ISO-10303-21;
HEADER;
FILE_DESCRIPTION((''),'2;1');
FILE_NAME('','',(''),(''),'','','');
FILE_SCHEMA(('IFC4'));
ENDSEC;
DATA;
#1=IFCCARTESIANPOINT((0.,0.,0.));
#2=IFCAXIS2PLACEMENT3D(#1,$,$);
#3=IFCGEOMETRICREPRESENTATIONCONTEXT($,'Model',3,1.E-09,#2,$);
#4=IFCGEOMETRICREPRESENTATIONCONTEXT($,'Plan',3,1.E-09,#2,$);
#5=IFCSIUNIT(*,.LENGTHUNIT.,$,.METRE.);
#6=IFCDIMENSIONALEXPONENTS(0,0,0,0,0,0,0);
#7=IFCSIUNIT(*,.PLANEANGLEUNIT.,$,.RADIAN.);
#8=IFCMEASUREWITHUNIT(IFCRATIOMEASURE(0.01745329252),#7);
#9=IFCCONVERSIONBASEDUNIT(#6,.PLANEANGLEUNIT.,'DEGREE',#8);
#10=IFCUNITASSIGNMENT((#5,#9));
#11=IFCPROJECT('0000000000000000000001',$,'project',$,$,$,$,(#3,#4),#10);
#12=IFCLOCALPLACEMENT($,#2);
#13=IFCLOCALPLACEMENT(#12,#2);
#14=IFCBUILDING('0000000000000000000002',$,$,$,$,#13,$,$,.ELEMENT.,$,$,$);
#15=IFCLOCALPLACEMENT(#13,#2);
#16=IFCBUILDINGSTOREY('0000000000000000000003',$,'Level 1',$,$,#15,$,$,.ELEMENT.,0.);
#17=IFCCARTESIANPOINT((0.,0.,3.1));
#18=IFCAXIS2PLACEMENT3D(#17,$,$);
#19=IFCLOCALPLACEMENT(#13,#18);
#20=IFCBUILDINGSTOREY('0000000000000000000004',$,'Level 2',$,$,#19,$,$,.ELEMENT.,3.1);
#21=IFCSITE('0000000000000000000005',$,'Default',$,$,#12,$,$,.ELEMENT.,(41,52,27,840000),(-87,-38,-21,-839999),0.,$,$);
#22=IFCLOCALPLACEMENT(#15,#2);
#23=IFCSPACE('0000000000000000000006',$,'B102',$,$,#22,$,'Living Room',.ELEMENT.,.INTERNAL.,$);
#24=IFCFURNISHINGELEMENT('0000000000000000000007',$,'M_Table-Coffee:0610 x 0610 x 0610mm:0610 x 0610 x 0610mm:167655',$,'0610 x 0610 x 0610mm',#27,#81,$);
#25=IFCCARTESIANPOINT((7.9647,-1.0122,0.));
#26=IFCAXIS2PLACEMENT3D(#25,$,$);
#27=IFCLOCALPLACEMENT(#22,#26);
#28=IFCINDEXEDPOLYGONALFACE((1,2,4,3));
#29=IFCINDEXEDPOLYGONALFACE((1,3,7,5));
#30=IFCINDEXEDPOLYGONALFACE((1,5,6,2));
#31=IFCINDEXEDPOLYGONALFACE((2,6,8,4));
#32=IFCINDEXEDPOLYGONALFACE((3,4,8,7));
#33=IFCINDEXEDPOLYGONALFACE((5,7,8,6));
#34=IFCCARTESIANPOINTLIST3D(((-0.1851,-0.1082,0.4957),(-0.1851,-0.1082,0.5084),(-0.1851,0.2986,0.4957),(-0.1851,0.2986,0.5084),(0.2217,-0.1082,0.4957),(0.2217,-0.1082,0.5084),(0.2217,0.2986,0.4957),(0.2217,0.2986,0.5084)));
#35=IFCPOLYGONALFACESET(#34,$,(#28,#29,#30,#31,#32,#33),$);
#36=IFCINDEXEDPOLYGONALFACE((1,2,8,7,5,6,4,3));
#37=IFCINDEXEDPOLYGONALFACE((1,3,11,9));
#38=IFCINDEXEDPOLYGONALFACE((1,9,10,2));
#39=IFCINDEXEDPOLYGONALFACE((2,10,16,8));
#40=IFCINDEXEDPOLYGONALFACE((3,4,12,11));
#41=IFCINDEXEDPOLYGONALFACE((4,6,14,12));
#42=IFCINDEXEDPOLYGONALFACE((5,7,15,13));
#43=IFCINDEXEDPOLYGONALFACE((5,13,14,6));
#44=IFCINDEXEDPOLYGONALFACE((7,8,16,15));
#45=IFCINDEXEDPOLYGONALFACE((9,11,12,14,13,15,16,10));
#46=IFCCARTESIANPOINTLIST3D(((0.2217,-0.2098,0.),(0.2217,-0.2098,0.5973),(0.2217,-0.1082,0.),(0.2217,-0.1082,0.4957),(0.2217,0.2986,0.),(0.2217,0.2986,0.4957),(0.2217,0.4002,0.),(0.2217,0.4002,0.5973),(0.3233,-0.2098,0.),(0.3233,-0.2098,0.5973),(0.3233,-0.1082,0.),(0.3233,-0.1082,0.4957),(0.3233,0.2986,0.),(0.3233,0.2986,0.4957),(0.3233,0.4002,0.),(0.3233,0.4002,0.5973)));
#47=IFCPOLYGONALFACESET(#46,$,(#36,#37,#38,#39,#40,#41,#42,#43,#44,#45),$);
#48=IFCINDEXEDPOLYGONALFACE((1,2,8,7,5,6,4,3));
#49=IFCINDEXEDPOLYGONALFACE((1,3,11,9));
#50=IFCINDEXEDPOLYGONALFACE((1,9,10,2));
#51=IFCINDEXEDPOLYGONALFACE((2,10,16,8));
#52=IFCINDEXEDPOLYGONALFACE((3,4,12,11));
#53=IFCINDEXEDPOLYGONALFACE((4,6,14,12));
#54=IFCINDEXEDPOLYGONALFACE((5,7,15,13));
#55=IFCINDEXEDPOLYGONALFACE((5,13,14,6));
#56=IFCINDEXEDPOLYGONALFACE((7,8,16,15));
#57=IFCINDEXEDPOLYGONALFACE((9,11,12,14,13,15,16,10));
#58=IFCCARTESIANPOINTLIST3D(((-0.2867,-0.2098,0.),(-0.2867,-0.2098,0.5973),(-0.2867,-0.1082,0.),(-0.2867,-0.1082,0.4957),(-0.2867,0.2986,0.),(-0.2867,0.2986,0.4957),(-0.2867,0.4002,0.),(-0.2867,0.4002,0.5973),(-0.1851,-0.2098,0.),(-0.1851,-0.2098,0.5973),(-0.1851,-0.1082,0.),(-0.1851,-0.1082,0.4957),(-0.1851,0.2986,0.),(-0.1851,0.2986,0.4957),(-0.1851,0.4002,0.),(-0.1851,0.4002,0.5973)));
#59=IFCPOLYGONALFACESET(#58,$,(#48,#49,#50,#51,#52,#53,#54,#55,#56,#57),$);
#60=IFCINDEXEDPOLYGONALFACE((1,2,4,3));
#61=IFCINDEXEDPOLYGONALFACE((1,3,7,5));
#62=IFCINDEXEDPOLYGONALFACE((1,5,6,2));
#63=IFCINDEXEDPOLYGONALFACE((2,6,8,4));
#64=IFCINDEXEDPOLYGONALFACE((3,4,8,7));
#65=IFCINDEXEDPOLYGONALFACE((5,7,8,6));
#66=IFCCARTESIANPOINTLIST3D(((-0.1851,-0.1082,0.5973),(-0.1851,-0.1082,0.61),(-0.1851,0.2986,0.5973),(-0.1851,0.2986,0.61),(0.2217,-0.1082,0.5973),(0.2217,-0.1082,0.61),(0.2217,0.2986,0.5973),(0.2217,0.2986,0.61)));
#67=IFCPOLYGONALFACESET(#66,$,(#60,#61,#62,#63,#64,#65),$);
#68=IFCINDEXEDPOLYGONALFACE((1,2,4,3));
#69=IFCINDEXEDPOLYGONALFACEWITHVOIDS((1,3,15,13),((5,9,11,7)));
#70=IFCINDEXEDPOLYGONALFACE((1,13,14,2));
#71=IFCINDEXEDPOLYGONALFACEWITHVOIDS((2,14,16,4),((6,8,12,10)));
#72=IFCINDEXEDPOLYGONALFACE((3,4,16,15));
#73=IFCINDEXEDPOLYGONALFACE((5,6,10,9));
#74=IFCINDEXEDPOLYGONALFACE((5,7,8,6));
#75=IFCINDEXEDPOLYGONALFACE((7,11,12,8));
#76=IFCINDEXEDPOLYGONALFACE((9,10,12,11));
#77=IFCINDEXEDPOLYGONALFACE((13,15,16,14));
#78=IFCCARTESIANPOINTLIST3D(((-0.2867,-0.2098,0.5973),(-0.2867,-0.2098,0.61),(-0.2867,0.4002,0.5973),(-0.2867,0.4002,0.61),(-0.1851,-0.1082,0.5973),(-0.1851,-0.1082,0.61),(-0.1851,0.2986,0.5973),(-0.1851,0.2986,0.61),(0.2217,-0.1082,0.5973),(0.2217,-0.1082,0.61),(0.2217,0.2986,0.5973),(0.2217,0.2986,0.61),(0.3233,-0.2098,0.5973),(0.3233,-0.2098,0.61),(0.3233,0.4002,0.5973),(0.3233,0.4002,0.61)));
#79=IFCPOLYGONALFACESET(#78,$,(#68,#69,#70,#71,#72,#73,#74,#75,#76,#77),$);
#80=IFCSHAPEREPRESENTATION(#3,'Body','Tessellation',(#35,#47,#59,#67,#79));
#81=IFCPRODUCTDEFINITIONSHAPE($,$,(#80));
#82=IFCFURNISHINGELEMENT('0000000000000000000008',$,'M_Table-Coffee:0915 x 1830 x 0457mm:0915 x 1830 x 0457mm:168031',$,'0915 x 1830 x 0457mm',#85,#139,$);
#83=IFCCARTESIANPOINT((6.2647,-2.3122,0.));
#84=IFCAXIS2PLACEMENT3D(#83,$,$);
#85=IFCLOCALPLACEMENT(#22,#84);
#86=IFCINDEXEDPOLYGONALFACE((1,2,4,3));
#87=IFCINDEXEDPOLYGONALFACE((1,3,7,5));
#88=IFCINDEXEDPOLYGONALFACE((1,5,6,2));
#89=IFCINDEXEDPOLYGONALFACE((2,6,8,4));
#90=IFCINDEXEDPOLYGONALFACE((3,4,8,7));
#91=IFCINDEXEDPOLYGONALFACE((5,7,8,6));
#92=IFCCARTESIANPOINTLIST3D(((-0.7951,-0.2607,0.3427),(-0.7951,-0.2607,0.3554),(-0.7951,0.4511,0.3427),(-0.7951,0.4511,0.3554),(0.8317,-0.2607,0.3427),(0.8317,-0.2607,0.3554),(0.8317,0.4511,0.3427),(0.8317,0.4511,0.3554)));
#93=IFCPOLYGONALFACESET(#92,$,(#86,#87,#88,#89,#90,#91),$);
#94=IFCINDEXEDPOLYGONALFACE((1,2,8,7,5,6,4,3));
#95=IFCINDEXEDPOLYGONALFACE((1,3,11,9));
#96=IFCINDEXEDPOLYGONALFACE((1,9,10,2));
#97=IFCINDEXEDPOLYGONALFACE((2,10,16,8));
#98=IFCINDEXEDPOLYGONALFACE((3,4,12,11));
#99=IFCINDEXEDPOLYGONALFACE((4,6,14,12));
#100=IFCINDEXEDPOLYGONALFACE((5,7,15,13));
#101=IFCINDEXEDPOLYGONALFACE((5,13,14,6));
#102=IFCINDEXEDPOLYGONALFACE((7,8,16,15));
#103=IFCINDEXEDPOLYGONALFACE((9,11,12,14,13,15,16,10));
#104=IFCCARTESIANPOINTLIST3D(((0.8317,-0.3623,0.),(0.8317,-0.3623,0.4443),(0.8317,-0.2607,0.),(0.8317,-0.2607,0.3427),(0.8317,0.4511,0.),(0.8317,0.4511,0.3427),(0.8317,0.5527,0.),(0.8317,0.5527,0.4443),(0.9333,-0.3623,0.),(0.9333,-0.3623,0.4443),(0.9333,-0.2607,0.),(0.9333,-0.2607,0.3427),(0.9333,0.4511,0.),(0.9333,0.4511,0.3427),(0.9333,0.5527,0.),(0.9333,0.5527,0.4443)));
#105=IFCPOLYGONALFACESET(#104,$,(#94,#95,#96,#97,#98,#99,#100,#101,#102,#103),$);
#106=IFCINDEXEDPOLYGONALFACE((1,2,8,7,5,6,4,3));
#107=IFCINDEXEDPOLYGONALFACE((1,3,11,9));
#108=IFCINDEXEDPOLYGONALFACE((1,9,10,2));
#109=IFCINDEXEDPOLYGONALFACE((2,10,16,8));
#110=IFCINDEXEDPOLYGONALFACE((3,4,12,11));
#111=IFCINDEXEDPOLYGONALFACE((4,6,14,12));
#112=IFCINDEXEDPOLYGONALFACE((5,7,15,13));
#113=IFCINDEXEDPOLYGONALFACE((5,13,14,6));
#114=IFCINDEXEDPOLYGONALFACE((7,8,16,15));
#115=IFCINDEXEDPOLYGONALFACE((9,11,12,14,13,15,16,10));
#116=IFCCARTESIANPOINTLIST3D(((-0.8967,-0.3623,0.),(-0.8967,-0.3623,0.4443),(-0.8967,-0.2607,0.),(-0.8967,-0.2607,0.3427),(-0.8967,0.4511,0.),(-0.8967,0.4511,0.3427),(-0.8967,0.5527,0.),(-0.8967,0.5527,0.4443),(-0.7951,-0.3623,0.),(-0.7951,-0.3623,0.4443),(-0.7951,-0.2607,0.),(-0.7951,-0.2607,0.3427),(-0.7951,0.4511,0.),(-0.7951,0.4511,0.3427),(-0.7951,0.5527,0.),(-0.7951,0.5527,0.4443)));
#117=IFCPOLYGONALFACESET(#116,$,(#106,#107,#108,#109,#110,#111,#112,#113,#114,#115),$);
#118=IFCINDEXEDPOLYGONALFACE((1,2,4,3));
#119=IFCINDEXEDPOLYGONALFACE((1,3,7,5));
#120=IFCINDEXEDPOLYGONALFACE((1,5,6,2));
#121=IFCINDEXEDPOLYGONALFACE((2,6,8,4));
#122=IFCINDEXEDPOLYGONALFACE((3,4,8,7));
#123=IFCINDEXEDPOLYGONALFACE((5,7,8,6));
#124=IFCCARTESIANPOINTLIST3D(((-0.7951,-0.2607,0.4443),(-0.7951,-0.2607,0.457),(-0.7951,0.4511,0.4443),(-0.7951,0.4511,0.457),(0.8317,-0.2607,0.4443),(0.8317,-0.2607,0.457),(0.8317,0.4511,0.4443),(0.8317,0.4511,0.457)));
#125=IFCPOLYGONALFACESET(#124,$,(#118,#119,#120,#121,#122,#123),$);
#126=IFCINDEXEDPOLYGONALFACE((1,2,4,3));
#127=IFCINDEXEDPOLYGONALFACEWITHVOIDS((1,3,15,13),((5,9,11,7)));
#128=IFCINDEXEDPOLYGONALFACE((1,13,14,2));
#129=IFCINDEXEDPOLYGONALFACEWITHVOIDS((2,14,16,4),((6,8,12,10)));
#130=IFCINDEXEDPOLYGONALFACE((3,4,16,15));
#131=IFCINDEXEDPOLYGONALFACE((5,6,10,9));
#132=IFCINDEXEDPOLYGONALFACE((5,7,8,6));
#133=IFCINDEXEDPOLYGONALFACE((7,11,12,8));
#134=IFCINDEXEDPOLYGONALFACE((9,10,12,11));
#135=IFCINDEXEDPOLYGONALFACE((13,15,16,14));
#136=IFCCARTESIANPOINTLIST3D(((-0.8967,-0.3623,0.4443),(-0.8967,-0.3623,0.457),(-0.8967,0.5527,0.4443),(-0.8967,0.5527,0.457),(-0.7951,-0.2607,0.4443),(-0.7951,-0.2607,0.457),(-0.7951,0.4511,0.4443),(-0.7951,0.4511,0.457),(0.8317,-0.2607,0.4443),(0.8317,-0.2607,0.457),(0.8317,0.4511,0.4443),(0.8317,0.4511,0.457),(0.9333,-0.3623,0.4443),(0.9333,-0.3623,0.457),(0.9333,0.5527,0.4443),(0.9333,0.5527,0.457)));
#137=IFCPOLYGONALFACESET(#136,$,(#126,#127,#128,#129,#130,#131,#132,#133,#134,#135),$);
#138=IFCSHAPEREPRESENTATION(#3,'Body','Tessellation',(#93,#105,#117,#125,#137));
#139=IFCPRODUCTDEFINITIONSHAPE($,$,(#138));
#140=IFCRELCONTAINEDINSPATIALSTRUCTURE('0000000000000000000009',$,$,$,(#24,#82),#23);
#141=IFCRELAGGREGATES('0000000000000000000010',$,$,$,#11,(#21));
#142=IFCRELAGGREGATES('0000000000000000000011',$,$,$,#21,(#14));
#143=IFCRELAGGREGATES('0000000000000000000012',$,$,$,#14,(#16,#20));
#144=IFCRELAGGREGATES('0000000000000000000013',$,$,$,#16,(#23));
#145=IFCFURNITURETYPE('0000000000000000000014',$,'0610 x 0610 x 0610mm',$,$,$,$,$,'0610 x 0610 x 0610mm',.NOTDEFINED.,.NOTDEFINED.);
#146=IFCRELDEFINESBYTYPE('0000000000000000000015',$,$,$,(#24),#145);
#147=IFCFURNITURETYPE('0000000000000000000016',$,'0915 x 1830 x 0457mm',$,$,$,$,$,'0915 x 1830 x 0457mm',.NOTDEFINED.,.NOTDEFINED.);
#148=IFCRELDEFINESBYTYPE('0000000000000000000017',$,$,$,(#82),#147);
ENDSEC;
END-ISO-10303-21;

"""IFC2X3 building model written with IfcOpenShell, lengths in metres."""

from ifc_helpers import new_model, entity, si_unit, converted_unit, frame, origin, origin_2d_with_axis, place, context, project, spatial, polyline, rectangle, outline, extrude, source, transform, mapped, type_object, type_shapes, element, save


model = new_model("IFC2X3")

# Units and contexts
model_context = context("Model", 3, precision=1e-09, world=origin())
plan_context = context("Plan", 3, precision=1e-09, world=origin())
ifc_project = project(units=[si_unit("LENGTHUNIT", "METRE"), converted_unit("PLANEANGLEUNIT", "DEGREE", entity("IfcRatioMeasure", 0.01745329252), si_unit("PLANEANGLEUNIT", "RADIAN"), dimensions=[0, 0, 0, 0, 0, 0, 0])], contexts=[model_context, plan_context])

# Site, building, storey
site_placement = place(None, origin())
site = spatial("IfcSite", under=ifc_project, at=site_placement, Name="Default", CompositionType="ELEMENT", RefLatitude=(41, 52, 27, 840000), RefLongitude=(-87, -38, -21, -839999), RefElevation=0.0)
building_placement = place(site_placement, origin())
building = spatial("IfcBuilding", under=site, at=building_placement, CompositionType="ELEMENT")
storey_1_placement = place(building_placement, origin())
storey_1 = spatial("IfcBuildingStorey", under=building, at=storey_1_placement, Name="Level 1", CompositionType="ELEMENT", Elevation=0.0)

# Shared definitions
storey_2_placement = place(building_placement, frame((0.0, 0.0, 3.1)))
storey_2 = spatial("IfcBuildingStorey", under=building, at=storey_2_placement, Name="Level 2", CompositionType="ELEMENT", Elevation=3.1)

# Shared definitions
space_1_placement = place(storey_1_placement, origin())
space_1 = spatial("IfcSpace", under=storey_1, at=space_1_placement, Name="B102", LongName="Living Room", CompositionType="ELEMENT", InteriorOrExteriorSpace="INTERNAL")

# Furnishing elements
furniture_type_1 = type_object("IfcFurnitureType", Name="0610 x 0610 x 0610mm", ElementType="0610 x 0610 x 0610mm", AssemblyPlace="NOTDEFINED")
shared_shape_1 = source(origin(), model_context, "Body", "SweptSolid", [
    extrude(rectangle(XDim=0.4068, YDim=0.4068, at=origin_2d_with_axis()), frame((0.0183, 0.0952, 0.4957), z_axis=(0.0, 0.0, 1.0), x_axis=(-1.0, 0.0, 0.0)), (0.0, 0.0, 1.0), 0.0127),
    extrude(outline(polyline([(-0.2732, -0.305), (0.3241, -0.305), (0.3241, 0.305), (-0.2732, 0.305), (-0.2732, 0.2034), (0.2225, 0.2034), (0.2225, -0.2034), (-0.2732, -0.2034), (-0.2732, -0.305)])), frame((0.2217, 0.0952, 0.2732), z_axis=(1.0, 0.0, 0.0), x_axis=(0.0, 0.0, 1.0)), (0.0, 0.0, 1.0), 0.1016),
    extrude(outline(polyline([(-0.305, -0.3241), (0.305, -0.3241), (0.305, 0.2732), (0.2034, 0.2732), (0.2034, -0.2225), (-0.2034, -0.2225), (-0.2034, 0.2732), (-0.305, 0.2732), (-0.305, -0.3241)])), frame((-0.2867, 0.0952, 0.2732), z_axis=(1.0, 0.0, 0.0), x_axis=(0.0, -1.0, 0.0)), (0.0, 0.0, 1.0), 0.1016),
    extrude(rectangle(XDim=0.4068, YDim=0.4068, at=origin_2d_with_axis()), frame((0.0183, 0.0952, 0.5973), z_axis=(0.0, 0.0, 1.0), x_axis=(-1.0, 0.0, 0.0)), (0.0, 0.0, 1.0), 0.0127),
    extrude(outline(polyline([(-0.305, -0.305), (0.305, -0.305), (0.305, 0.305), (-0.305, 0.305), (-0.305, -0.305)]), holes=[polyline([(-0.2034, -0.2034), (-0.2034, 0.2034), (0.2034, 0.2034), (0.2034, -0.2034), (-0.2034, -0.2034)])]), frame((0.0183, 0.0952, 0.5973), z_axis=(0.0, 0.0, 1.0), x_axis=(-1.0, 0.0, 0.0)), (0.0, 0.0, 1.0), 0.0127),
])
type_shapes(furniture_type_1, [shared_shape_1])
for number, where, name in (
    (1, (7.9647, -1.0122, 0.0), "M_Table-Coffee:0610 x 0610 x 0610mm:0610 x 0610 x 0610mm:167655"),
):
    element("IfcFurnishingElement", number, at=place(space_1_placement, frame(where)), inside=space_1, type_object=furniture_type_1, Name=name, ObjectType="0610 x 0610 x 0610mm", context=model_context, shape_type="MappedRepresentation", body=[
        mapped(shared_shape_1, transform((0.0, 0.0, 0.0), scale=1.0)),
    ])
furniture_type_2 = type_object("IfcFurnitureType", Name="0915 x 1830 x 0457mm", ElementType="0915 x 1830 x 0457mm", AssemblyPlace="NOTDEFINED")
shared_shape_2 = source(origin(), model_context, "Body", "SweptSolid", [
    extrude(rectangle(XDim=1.6268, YDim=0.7118, at=origin_2d_with_axis()), frame((0.0183, 0.0952, 0.3427), z_axis=(0.0, 0.0, 1.0), x_axis=(-1.0, 0.0, 0.0)), (0.0, 0.0, 1.0), 0.0127),
    extrude(outline(polyline([(-0.1968, -0.4575), (0.2475, -0.4575), (0.2475, 0.4575), (-0.1968, 0.4575), (-0.1968, 0.3559), (0.1459, 0.3559), (0.1459, -0.3559), (-0.1968, -0.3559), (-0.1968, -0.4575)])), frame((0.8317, 0.0952, 0.1968), z_axis=(1.0, 0.0, 0.0), x_axis=(0.0, 0.0, 1.0)), (0.0, 0.0, 1.0), 0.1016),
    extrude(outline(polyline([(-0.4575, -0.2475), (0.4575, -0.2475), (0.4575, 0.1968), (0.3559, 0.1968), (0.3559, -0.1459), (-0.3559, -0.1459), (-0.3559, 0.1968), (-0.4575, 0.1968), (-0.4575, -0.2475)])), frame((-0.8967, 0.0952, 0.1968), z_axis=(1.0, 0.0, 0.0), x_axis=(0.0, -1.0, 0.0)), (0.0, 0.0, 1.0), 0.1016),
    extrude(rectangle(XDim=1.6268, YDim=0.7118, at=origin_2d_with_axis()), frame((0.0183, 0.0952, 0.4443), z_axis=(0.0, 0.0, 1.0), x_axis=(-1.0, 0.0, 0.0)), (0.0, 0.0, 1.0), 0.0127),
    extrude(outline(polyline([(-0.915, -0.4575), (0.915, -0.4575), (0.915, 0.4575), (-0.915, 0.4575), (-0.915, -0.4575)]), holes=[polyline([(-0.8134, -0.3559), (-0.8134, 0.3559), (0.8134, 0.3559), (0.8134, -0.3559), (-0.8134, -0.3559)])]), frame((0.0183, 0.0952, 0.4443), z_axis=(0.0, 0.0, 1.0), x_axis=(-1.0, 0.0, 0.0)), (0.0, 0.0, 1.0), 0.0127),
])
type_shapes(furniture_type_2, [shared_shape_2])
furnishing_1_placement = place(space_1_placement, frame((6.2647, -2.3122, 0.0)))
element("IfcFurnishingElement", 2, at=furnishing_1_placement, inside=space_1, type_object=furniture_type_2, Name="M_Table-Coffee:0915 x 1830 x 0457mm:0915 x 1830 x 0457mm:168031", ObjectType="0915 x 1830 x 0457mm", context=model_context, shape_type="MappedRepresentation", body=[
    mapped(shared_shape_2, transform((0.0, 0.0, 0.0), scale=1.0)),
])

save(model, "model.ifc")
